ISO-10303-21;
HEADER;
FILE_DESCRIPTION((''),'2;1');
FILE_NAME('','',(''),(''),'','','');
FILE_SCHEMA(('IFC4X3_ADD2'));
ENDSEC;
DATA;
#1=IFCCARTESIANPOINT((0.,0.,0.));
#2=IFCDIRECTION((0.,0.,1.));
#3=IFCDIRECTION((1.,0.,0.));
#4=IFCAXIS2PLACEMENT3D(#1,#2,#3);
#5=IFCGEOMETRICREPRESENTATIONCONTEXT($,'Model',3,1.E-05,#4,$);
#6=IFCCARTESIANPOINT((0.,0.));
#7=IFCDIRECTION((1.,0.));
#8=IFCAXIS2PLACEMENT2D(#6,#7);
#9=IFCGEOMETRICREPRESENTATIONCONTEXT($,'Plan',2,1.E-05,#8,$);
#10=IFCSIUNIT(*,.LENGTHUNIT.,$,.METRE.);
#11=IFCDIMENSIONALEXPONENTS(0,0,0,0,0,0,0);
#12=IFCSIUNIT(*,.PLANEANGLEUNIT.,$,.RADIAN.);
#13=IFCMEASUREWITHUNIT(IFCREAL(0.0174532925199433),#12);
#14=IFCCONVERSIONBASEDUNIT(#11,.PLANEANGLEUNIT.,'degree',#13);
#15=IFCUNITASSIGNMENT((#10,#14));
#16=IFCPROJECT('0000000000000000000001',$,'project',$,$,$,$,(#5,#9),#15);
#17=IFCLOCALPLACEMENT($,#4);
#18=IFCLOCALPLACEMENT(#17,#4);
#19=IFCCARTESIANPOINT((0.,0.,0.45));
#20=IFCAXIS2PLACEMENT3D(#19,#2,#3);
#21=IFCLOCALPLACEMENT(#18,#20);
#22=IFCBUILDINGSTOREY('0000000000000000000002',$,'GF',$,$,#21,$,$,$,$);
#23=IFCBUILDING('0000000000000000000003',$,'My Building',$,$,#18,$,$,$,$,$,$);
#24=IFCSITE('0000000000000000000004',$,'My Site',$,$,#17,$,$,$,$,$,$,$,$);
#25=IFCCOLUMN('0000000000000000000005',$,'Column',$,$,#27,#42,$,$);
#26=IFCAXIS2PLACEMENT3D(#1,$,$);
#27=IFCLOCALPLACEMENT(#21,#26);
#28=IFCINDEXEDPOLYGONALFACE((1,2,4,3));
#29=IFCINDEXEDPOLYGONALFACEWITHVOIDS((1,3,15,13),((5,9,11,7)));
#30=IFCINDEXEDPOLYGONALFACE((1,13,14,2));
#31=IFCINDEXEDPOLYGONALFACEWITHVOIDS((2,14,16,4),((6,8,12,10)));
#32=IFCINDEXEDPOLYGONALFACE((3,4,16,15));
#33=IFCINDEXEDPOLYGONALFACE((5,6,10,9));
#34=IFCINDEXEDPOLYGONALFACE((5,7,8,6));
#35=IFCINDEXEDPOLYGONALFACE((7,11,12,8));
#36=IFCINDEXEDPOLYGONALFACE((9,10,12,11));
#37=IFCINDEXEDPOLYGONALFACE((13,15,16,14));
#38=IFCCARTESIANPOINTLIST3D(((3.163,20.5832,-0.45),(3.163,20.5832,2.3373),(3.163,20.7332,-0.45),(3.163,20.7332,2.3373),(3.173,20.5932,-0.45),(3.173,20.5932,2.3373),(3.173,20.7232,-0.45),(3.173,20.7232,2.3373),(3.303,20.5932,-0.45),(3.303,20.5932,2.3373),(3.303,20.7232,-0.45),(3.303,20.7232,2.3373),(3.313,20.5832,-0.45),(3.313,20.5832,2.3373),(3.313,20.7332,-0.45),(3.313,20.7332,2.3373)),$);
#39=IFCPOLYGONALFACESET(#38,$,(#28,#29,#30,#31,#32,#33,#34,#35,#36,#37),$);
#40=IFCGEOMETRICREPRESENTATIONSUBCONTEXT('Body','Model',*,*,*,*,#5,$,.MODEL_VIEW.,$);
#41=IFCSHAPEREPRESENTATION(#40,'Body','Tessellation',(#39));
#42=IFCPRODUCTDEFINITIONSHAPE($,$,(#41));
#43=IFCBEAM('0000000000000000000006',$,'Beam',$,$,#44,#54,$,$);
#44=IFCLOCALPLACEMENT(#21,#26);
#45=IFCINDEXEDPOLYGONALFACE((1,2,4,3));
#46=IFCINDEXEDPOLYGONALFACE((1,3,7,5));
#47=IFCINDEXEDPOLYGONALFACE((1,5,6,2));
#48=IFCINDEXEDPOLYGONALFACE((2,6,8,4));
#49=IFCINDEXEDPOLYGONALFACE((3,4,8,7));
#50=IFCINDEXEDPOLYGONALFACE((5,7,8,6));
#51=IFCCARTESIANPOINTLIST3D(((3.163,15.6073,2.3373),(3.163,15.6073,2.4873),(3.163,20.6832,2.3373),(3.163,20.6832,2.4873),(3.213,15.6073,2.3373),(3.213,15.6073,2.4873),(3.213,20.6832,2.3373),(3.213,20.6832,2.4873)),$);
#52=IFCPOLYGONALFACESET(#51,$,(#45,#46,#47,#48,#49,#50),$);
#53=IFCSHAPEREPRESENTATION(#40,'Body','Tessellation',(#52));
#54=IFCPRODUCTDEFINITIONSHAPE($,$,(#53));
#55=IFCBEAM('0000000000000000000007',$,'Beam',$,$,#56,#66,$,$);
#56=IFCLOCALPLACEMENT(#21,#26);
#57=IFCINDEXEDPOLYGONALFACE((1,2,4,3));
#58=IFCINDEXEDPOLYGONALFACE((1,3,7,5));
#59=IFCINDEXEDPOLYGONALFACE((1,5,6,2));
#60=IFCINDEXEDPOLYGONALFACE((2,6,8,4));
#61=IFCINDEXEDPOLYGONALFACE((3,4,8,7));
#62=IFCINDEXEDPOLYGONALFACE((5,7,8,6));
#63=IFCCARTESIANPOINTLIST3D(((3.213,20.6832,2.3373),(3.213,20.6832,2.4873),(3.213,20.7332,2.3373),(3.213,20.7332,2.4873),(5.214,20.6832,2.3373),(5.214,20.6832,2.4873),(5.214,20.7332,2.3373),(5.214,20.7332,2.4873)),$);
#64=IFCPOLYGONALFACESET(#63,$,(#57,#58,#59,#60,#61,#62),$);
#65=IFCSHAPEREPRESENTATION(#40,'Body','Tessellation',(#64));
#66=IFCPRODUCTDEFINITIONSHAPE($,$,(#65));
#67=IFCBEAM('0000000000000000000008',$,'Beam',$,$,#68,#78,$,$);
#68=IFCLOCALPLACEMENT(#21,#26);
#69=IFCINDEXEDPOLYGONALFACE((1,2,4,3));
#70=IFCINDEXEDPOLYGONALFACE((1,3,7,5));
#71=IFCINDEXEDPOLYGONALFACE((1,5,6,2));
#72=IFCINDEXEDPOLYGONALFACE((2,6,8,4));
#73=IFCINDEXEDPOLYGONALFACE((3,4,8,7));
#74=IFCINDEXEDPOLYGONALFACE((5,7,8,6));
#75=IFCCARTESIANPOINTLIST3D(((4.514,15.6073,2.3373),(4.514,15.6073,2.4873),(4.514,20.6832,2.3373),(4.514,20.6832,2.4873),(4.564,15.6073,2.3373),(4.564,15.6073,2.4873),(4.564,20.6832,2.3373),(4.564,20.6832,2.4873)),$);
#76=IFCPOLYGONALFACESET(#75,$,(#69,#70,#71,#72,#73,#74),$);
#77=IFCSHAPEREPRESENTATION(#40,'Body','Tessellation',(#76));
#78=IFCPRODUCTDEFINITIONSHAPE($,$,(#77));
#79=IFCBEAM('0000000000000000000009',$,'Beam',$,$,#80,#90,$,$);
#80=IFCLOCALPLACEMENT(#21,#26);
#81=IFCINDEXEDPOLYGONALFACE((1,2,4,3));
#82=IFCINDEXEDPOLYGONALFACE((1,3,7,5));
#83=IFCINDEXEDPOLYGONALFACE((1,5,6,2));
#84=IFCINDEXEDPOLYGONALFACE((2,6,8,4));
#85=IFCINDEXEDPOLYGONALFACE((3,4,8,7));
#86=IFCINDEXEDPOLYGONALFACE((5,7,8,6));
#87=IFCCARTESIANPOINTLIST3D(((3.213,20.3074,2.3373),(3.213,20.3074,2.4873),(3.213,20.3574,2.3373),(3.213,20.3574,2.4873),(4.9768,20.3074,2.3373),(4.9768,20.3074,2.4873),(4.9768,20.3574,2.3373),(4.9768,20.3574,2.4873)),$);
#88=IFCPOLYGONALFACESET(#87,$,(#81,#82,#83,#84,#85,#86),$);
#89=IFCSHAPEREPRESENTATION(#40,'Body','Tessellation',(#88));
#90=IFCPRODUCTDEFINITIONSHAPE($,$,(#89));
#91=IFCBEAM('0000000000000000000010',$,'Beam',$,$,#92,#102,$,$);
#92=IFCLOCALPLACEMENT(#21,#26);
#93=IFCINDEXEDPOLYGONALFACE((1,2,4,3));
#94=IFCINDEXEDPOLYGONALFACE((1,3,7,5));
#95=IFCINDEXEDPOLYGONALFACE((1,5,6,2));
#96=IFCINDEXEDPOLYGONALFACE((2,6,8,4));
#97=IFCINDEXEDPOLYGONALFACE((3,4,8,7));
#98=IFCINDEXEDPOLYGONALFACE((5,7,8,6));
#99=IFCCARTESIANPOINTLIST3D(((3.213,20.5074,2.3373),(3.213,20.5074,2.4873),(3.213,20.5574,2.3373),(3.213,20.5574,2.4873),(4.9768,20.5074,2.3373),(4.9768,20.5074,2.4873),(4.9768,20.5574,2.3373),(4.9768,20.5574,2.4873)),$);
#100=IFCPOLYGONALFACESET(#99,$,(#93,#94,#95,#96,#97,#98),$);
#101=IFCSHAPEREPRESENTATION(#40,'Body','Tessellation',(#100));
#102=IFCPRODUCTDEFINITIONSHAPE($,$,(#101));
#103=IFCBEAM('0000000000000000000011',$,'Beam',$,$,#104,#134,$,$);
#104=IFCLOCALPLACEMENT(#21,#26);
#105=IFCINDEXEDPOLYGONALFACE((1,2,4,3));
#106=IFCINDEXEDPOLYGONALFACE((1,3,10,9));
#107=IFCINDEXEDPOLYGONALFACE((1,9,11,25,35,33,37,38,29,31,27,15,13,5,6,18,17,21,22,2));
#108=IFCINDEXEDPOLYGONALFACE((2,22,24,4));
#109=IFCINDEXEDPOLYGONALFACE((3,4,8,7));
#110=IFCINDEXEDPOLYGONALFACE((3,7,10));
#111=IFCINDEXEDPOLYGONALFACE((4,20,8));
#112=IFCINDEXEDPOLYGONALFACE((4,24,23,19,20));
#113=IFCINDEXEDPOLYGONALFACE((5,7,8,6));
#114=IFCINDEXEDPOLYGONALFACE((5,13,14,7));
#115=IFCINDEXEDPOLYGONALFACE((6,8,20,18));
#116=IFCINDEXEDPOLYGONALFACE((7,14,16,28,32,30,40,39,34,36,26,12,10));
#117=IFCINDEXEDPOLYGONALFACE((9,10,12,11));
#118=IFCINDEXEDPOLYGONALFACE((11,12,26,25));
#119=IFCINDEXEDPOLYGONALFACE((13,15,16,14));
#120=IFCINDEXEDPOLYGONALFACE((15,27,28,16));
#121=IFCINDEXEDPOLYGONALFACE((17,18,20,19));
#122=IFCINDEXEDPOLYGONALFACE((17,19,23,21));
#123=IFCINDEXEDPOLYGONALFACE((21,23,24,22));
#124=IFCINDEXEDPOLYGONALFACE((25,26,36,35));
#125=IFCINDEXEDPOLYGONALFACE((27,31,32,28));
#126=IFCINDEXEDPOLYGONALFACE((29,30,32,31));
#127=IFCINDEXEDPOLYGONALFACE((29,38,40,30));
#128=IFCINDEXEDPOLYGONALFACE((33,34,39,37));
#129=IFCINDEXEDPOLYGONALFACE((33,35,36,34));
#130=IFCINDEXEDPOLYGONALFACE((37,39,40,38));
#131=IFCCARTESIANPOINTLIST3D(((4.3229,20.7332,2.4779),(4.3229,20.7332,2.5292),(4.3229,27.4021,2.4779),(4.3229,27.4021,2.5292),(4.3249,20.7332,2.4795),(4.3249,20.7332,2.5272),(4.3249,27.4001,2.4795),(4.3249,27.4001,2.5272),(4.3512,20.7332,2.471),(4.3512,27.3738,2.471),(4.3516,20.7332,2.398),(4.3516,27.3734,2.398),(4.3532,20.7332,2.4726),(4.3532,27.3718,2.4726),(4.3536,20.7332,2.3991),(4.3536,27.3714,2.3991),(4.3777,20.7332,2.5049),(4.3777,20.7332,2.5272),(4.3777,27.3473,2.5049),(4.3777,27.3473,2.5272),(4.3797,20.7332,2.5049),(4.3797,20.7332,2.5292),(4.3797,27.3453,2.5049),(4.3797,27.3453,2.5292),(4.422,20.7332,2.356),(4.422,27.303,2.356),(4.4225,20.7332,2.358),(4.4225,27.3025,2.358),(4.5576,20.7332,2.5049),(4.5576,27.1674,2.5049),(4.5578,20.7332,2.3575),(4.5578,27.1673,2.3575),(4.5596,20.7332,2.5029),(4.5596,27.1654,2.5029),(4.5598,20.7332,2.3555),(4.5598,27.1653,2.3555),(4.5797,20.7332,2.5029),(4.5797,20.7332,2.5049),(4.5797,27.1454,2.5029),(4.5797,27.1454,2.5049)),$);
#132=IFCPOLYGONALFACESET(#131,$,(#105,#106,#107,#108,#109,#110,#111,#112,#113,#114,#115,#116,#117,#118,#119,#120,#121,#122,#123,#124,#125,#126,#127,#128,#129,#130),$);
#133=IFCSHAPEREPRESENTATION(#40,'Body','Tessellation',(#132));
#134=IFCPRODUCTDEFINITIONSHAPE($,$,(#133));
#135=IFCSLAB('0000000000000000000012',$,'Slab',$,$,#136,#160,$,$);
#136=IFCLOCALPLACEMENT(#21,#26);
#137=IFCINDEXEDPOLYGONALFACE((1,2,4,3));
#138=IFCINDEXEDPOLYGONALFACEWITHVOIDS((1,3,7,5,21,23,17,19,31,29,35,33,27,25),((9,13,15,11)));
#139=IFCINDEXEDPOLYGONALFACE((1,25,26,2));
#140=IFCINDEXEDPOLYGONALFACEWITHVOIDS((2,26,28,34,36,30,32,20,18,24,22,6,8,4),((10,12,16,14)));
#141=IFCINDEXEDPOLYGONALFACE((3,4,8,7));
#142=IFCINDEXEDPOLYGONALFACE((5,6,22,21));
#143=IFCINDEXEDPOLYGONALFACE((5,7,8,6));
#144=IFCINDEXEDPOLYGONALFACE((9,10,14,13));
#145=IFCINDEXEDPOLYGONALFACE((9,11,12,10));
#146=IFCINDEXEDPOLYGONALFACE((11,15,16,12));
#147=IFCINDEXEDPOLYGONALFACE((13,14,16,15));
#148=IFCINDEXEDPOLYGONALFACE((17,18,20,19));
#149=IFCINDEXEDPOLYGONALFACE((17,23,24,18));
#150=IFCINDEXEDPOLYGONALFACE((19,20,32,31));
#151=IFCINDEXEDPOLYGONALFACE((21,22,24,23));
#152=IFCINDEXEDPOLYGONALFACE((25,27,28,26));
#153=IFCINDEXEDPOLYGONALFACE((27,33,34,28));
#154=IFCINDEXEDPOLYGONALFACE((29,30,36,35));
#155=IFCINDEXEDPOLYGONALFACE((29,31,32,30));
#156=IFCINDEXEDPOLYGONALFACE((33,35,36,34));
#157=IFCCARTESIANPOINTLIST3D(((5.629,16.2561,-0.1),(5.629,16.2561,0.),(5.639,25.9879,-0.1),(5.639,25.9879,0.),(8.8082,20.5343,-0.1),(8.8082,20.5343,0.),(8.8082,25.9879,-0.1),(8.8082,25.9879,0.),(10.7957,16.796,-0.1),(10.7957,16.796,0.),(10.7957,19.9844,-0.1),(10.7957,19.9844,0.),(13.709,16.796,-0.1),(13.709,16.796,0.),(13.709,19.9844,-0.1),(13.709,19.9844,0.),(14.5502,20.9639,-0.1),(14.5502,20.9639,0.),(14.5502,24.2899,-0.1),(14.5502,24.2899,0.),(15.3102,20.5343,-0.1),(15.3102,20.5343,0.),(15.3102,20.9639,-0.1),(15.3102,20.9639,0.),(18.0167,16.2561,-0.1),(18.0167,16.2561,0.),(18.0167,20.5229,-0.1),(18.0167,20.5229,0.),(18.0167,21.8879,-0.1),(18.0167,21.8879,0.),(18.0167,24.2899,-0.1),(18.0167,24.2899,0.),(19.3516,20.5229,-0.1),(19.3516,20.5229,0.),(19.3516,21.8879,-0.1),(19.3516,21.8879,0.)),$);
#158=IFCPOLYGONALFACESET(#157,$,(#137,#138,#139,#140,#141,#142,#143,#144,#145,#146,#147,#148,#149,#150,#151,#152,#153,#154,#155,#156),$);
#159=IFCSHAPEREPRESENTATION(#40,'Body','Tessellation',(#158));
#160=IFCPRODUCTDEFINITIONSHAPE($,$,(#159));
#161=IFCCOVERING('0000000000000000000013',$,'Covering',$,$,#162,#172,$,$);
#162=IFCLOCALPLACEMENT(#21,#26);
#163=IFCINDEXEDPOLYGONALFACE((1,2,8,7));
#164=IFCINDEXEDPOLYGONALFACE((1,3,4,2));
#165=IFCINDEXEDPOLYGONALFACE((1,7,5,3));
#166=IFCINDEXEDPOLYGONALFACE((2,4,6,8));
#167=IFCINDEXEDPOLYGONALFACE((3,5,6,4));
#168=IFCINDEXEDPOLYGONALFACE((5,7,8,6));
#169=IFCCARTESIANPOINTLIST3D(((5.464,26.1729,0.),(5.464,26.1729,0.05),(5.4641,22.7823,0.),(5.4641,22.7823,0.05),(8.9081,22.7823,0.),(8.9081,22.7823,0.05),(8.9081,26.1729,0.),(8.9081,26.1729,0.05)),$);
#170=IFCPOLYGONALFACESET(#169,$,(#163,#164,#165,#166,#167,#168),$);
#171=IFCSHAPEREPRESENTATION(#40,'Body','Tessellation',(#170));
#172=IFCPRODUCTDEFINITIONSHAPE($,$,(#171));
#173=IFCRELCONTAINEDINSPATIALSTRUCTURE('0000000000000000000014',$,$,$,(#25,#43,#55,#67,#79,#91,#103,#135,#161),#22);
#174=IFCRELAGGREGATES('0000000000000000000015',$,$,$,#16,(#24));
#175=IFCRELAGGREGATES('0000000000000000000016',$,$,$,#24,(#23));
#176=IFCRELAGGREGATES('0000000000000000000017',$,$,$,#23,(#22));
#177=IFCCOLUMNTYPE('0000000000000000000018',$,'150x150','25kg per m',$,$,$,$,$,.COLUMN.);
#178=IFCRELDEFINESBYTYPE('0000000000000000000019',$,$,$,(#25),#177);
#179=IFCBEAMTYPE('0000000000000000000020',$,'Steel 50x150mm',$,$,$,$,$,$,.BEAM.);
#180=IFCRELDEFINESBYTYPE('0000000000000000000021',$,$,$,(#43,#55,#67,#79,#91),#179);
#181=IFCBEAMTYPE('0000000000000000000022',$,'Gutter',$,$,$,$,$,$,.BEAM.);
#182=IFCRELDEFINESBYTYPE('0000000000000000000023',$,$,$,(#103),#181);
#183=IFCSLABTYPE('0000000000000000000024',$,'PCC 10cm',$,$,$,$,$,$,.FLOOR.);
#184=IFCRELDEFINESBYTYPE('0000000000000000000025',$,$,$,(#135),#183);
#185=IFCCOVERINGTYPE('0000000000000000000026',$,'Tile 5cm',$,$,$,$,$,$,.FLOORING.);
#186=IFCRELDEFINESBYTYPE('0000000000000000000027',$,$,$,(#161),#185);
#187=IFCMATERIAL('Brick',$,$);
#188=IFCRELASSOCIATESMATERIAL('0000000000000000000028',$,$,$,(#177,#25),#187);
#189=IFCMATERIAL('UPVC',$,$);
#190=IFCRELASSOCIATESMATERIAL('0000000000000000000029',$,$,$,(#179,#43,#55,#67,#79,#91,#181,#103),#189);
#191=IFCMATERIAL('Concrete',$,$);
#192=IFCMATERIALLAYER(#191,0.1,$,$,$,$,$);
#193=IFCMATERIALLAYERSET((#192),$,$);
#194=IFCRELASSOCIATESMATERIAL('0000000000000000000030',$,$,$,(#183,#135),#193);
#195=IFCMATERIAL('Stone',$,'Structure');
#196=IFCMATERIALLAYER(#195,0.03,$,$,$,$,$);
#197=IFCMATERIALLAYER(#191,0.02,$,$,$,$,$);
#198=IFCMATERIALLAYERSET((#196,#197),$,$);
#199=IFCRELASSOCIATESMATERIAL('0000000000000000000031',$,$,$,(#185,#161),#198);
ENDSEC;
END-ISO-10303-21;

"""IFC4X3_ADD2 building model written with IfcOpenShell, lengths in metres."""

from ifc_helpers import new_model, entity, si_unit, converted_unit, frame, origin_with_axes, origin_2d_with_axis, place, context, subcontext, project, spatial, indexed_curve, rectangle, hollow_rectangle, outline, extrude, clip, halfspace, shape, material, layer, layer_set, layer_usage, material_profile, profile_set, profile_usage, type_object, element, save


model = new_model("IFC4X3_ADD2")

# Units and contexts
model_context = context("Model", 3, precision=1e-05, world=origin_with_axes())
plan_context = context("Plan", 2, precision=1e-05, world=origin_2d_with_axis())
body_context_1 = subcontext(model_context, "Body", "Model", "MODEL_VIEW")
body_context_2 = subcontext(plan_context, "Body", "Plan", "PLAN_VIEW")
ifc_project = project(units=[si_unit("LENGTHUNIT", "METRE"), converted_unit("PLANEANGLEUNIT", "degree", entity("IfcReal", 0.0174532925199433), si_unit("PLANEANGLEUNIT", "RADIAN"), dimensions=[0, 0, 0, 0, 0, 0, 0])], contexts=[model_context, plan_context])

# Site, building, storey
site_placement = place(None, origin_with_axes())
site = spatial("IfcSite", under=ifc_project, at=site_placement, Name="My Site")
building_placement = place(site_placement, origin_with_axes())
building = spatial("IfcBuilding", under=site, at=building_placement, Name="My Building")
storey_placement = place(building_placement, frame((0.0, 0.0, 0.45), z_axis=(0.0, 0.0, 1.0), x_axis=(1.0, 0.0, 0.0)))
storey = spatial("IfcBuildingStorey", under=building, at=storey_placement, Name="GF")

# Column
ifc_material_1 = material(Name="Brick")
ifc_material_profile_1 = material_profile(ifc_material_1, hollow_rectangle(XDim=0.15, YDim=0.15, WallThickness=0.01))
ifc_profile_set_1 = profile_set([ifc_material_profile_1])
ifc_profile_usage_1 = profile_usage(ifc_profile_set_1, cardinal=5)
column_type = type_object("IfcColumnType", Name="150x150", Description="25kg per m", PredefinedType="COLUMN", material=ifc_profile_set_1)
column_placement = place(storey_placement, frame((3.238, 20.6582, -0.45), z_axis=(0.0, 0.0, 1.0), x_axis=(1.0, 0.0, 0.0)))
element("IfcColumn", 1, at=column_placement, inside=storey, type_object=column_type, material=ifc_profile_usage_1, Name="Column", shapes=[
    shape(body_context_1, "Body", "SweptSolid", [extrude(hollow_rectangle(XDim=0.15, YDim=0.15, WallThickness=0.01), origin_with_axes(), (0.0, 0.0, 1.0), 2.7873)]),
    shape(body_context_2, "Body", "Annotation2D", [entity("IfcGeometricCurveSet", [entity("IfcIndexedPolyCurve", entity("IfcCartesianPointList2D", [[-0.075, -0.075], [0.075, -0.075], [0.075, 0.075], [-0.075, 0.075]]), [entity("IfcLineIndex", [1, 2, 3, 4, 1])]), entity("IfcIndexedPolyCurve", entity("IfcCartesianPointList2D", [[-0.065, 0.065], [0.065, 0.065], [0.065, -0.065], [-0.065, -0.065]]), [entity("IfcLineIndex", [1, 2, 3, 4, 1])])])]),
])

# Beams
ifc_material_2 = material(Name="UPVC")
ifc_material_profile_2 = material_profile(ifc_material_2, rectangle(XDim=0.05, YDim=0.15))
ifc_profile_set_2 = profile_set([ifc_material_profile_2])
ifc_profile_usage_2 = profile_usage(ifc_profile_set_2)
beam_type_1 = type_object("IfcBeamType", Name="Steel 50x150mm", PredefinedType="BEAM", material=ifc_profile_set_2)
beam_1_placement = place(storey_placement, frame((3.188, 20.6832, 2.4123), z_axis=(0.0, -1.0, 0.0), x_axis=(1.0, 0.0, 0.0)))
element("IfcBeam", 2, at=beam_1_placement, inside=storey, type_object=beam_type_1, material=ifc_profile_usage_2, Name="Beam", context=body_context_1, shape_type="SweptSolid", body=[
    extrude(rectangle(XDim=0.05, YDim=0.15), origin_with_axes(), (0.0, 0.0, 1.0), 5.0758),
])
ifc_profile_usage_3 = profile_usage(ifc_profile_set_2)
beam_2_placement = place(storey_placement, frame((3.213, 20.7082, 2.4123), z_axis=(1.0, 0.0, 0.0), x_axis=(0.0, 1.0, 0.0)))
element("IfcBeam", 3, at=beam_2_placement, inside=storey, type_object=beam_type_1, material=ifc_profile_usage_3, Name="Beam", context=body_context_1, shape_type="SweptSolid", body=[
    extrude(rectangle(XDim=0.05, YDim=0.15), origin_with_axes(), (0.0, 0.0, 1.0), 2.001),
])
ifc_profile_usage_4 = profile_usage(ifc_profile_set_2)
beam_3_placement = place(storey_placement, frame((4.539, 20.6832, 2.4123), z_axis=(0.0, -1.0, 0.0), x_axis=(1.0, 0.0, 0.0)))
element("IfcBeam", 4, at=beam_3_placement, inside=storey, type_object=beam_type_1, material=ifc_profile_usage_4, Name="Beam", context=body_context_1, shape_type="SweptSolid", body=[
    extrude(rectangle(XDim=0.05, YDim=0.15), origin_with_axes(), (0.0, 0.0, 1.0), 5.0758),
])
ifc_profile_usage_5 = profile_usage(ifc_profile_set_2)
beam_4_placement = place(storey_placement, frame((3.213, 20.3324, 2.4123), z_axis=(1.0, 0.0, 0.0), x_axis=(0.0, 1.0, 0.0)))
element("IfcBeam", 5, at=beam_4_placement, inside=storey, type_object=beam_type_1, material=ifc_profile_usage_5, Name="Beam", context=body_context_1, shape_type="SweptSolid", body=[
    extrude(rectangle(XDim=0.05, YDim=0.15), origin_with_axes(), (0.0, 0.0, 1.0), 1.7638),
])
ifc_profile_usage_6 = profile_usage(ifc_profile_set_2)
beam_5_placement = place(storey_placement, frame((3.213, 20.5324, 2.4123), z_axis=(1.0, 0.0, 0.0), x_axis=(0.0, 1.0, 0.0)))
element("IfcBeam", 6, at=beam_5_placement, inside=storey, type_object=beam_type_1, material=ifc_profile_usage_6, Name="Beam", context=body_context_1, shape_type="SweptSolid", body=[
    extrude(rectangle(XDim=0.05, YDim=0.15), origin_with_axes(), (0.0, 0.0, 1.0), 1.7638),
])
ifc_material_profile_3 = material_profile(ifc_material_2, outline(indexed_curve([(0.0548, 0.1717), (0.002, 0.1717), (0.002, 0.124), (0.0303, 0.1171), (0.0307, 0.0436), (0.0996, 0.0025), (0.2349, 0.002), (0.2347, 0.1494), (0.2567, 0.1494), (0.2567, 0.1474), (0.2367, 0.1474), (0.2369, 0.0), (0.0991, 0.0005), (0.0287, 0.0425), (0.0283, 0.1155), (0.0, 0.1224), (0.0, 0.1737), (0.0568, 0.1737), (0.0568, 0.1494), (0.0548, 0.1494), (0.0548, 0.1717)])))
ifc_profile_set_3 = profile_set([ifc_material_profile_3])
ifc_profile_usage_7 = profile_usage(ifc_profile_set_3, cardinal=5)
beam_type_2 = type_object("IfcBeamType", Name="Gutter", PredefinedType="BEAM", material=ifc_profile_set_3)
beam_6_placement = place(storey_placement, frame((4.3229, 27.4021, 2.3555), z_axis=(0.0, -1.0, 0.0), x_axis=(1.0, 0.0, 0.0)))
element("IfcBeam", 7, at=beam_6_placement, inside=storey, type_object=beam_type_2, material=ifc_profile_usage_7, Name="Beam", context=body_context_1, shape_type="Clipping", body=[
    clip(extrude(outline(indexed_curve([(0.0548, 0.1717), (0.002, 0.1717), (0.002, 0.124), (0.0303, 0.1171), (0.0307, 0.0436), (0.0996, 0.0025), (0.2349, 0.002), (0.2347, 0.1494), (0.2567, 0.1494), (0.2567, 0.1474), (0.2367, 0.1474), (0.2369, 0.0), (0.0991, 0.0005), (0.0287, 0.0425), (0.0283, 0.1155), (0.0, 0.1224), (0.0, 0.1737), (0.0568, 0.1737), (0.0568, 0.1494), (0.0548, 0.1494), (0.0548, 0.1717)])), origin_with_axes(), (0.0, 0.0, 1.0), 6.669), halfspace(frame((0.0, -2.8055, 0.0), z_axis=(0.707107, 0.0, -0.707107), x_axis=(0.0, -1.0, 0.0)), False)),
])

# Slab
ifc_material_3 = material(Name="Concrete")
ifc_layer_1 = layer(ifc_material_3, 0.1)
ifc_layer_set_1 = layer_set([ifc_layer_1])
ifc_layer_usage_1 = layer_usage(ifc_layer_set_1, "AXIS3", "POSITIVE", -0.1)
slab_type = type_object("IfcSlabType", Name="PCC 10cm", PredefinedType="FLOOR", material=ifc_layer_set_1)
slab_1_placement = place(storey_placement, frame((5.639, 25.9879, 0.0), z_axis=(0.0, 0.0, 1.0), x_axis=(1.0, 0.0, 0.0)))
element("IfcSlab", 8, at=slab_1_placement, inside=storey, type_object=slab_type, material=ifc_layer_usage_1, Name="Slab", context=body_context_1, shape_type="SweptSolid", body=[
    extrude(outline(indexed_curve([(-0.01, -9.7318), (12.3776, -9.7318), (12.3776, -5.465), (13.7126, -5.465), (13.7126, -4.1), (12.3777, -4.1), (12.3777, -1.698), (8.9112, -1.698), (8.9112, -5.024), (9.6712, -5.024), (9.6712, -5.4536), (3.1692, -5.4536), (3.1692, 0.0), (0.0, 0.0), (-0.01, -9.7318)]), holes=[indexed_curve([(5.1566, -9.1919), (8.0699, -9.1919), (8.0699, -6.0035), (5.1567, -6.0035), (5.1566, -9.1919)])]), frame((0.0, 0.0, -0.1), z_axis=(0.0, 0.0, 1.0), x_axis=(1.0, 0.0, 0.0)), (0.0, 0.0, 1.0), 0.1),
])

# Covering
ifc_material_4 = material(Name="Stone", Category="Structure")
ifc_layer_2 = layer(ifc_material_4, 0.03)
ifc_layer_3 = layer(ifc_material_3, 0.02)
ifc_layer_set_2 = layer_set([ifc_layer_2, ifc_layer_3])
ifc_layer_usage_2 = layer_usage(ifc_layer_set_2, "AXIS3", "POSITIVE", 0.0)
covering_type = type_object("IfcCoveringType", Name="Tile 5cm", PredefinedType="FLOORING", material=ifc_layer_set_2)
covering_1_placement = place(storey_placement, frame((5.464, 26.1729, 0.0), z_axis=(0.0, 0.0, 1.0), x_axis=(1.0, 0.0, 0.0)))
element("IfcCovering", 9, at=covering_1_placement, inside=storey, type_object=covering_type, material=ifc_layer_usage_2, Name="Covering", context=body_context_1, shape_type="SweptSolid", body=[
    extrude(outline(indexed_curve([(0.0, 0.0), (3.4441, 0.0), (3.4441, -3.3906), (0.0, -3.3906), (0.0, 0.0)])), None, (0.0, 0.0, 1.0), 0.05),
])

save(model, "model.ifc")
